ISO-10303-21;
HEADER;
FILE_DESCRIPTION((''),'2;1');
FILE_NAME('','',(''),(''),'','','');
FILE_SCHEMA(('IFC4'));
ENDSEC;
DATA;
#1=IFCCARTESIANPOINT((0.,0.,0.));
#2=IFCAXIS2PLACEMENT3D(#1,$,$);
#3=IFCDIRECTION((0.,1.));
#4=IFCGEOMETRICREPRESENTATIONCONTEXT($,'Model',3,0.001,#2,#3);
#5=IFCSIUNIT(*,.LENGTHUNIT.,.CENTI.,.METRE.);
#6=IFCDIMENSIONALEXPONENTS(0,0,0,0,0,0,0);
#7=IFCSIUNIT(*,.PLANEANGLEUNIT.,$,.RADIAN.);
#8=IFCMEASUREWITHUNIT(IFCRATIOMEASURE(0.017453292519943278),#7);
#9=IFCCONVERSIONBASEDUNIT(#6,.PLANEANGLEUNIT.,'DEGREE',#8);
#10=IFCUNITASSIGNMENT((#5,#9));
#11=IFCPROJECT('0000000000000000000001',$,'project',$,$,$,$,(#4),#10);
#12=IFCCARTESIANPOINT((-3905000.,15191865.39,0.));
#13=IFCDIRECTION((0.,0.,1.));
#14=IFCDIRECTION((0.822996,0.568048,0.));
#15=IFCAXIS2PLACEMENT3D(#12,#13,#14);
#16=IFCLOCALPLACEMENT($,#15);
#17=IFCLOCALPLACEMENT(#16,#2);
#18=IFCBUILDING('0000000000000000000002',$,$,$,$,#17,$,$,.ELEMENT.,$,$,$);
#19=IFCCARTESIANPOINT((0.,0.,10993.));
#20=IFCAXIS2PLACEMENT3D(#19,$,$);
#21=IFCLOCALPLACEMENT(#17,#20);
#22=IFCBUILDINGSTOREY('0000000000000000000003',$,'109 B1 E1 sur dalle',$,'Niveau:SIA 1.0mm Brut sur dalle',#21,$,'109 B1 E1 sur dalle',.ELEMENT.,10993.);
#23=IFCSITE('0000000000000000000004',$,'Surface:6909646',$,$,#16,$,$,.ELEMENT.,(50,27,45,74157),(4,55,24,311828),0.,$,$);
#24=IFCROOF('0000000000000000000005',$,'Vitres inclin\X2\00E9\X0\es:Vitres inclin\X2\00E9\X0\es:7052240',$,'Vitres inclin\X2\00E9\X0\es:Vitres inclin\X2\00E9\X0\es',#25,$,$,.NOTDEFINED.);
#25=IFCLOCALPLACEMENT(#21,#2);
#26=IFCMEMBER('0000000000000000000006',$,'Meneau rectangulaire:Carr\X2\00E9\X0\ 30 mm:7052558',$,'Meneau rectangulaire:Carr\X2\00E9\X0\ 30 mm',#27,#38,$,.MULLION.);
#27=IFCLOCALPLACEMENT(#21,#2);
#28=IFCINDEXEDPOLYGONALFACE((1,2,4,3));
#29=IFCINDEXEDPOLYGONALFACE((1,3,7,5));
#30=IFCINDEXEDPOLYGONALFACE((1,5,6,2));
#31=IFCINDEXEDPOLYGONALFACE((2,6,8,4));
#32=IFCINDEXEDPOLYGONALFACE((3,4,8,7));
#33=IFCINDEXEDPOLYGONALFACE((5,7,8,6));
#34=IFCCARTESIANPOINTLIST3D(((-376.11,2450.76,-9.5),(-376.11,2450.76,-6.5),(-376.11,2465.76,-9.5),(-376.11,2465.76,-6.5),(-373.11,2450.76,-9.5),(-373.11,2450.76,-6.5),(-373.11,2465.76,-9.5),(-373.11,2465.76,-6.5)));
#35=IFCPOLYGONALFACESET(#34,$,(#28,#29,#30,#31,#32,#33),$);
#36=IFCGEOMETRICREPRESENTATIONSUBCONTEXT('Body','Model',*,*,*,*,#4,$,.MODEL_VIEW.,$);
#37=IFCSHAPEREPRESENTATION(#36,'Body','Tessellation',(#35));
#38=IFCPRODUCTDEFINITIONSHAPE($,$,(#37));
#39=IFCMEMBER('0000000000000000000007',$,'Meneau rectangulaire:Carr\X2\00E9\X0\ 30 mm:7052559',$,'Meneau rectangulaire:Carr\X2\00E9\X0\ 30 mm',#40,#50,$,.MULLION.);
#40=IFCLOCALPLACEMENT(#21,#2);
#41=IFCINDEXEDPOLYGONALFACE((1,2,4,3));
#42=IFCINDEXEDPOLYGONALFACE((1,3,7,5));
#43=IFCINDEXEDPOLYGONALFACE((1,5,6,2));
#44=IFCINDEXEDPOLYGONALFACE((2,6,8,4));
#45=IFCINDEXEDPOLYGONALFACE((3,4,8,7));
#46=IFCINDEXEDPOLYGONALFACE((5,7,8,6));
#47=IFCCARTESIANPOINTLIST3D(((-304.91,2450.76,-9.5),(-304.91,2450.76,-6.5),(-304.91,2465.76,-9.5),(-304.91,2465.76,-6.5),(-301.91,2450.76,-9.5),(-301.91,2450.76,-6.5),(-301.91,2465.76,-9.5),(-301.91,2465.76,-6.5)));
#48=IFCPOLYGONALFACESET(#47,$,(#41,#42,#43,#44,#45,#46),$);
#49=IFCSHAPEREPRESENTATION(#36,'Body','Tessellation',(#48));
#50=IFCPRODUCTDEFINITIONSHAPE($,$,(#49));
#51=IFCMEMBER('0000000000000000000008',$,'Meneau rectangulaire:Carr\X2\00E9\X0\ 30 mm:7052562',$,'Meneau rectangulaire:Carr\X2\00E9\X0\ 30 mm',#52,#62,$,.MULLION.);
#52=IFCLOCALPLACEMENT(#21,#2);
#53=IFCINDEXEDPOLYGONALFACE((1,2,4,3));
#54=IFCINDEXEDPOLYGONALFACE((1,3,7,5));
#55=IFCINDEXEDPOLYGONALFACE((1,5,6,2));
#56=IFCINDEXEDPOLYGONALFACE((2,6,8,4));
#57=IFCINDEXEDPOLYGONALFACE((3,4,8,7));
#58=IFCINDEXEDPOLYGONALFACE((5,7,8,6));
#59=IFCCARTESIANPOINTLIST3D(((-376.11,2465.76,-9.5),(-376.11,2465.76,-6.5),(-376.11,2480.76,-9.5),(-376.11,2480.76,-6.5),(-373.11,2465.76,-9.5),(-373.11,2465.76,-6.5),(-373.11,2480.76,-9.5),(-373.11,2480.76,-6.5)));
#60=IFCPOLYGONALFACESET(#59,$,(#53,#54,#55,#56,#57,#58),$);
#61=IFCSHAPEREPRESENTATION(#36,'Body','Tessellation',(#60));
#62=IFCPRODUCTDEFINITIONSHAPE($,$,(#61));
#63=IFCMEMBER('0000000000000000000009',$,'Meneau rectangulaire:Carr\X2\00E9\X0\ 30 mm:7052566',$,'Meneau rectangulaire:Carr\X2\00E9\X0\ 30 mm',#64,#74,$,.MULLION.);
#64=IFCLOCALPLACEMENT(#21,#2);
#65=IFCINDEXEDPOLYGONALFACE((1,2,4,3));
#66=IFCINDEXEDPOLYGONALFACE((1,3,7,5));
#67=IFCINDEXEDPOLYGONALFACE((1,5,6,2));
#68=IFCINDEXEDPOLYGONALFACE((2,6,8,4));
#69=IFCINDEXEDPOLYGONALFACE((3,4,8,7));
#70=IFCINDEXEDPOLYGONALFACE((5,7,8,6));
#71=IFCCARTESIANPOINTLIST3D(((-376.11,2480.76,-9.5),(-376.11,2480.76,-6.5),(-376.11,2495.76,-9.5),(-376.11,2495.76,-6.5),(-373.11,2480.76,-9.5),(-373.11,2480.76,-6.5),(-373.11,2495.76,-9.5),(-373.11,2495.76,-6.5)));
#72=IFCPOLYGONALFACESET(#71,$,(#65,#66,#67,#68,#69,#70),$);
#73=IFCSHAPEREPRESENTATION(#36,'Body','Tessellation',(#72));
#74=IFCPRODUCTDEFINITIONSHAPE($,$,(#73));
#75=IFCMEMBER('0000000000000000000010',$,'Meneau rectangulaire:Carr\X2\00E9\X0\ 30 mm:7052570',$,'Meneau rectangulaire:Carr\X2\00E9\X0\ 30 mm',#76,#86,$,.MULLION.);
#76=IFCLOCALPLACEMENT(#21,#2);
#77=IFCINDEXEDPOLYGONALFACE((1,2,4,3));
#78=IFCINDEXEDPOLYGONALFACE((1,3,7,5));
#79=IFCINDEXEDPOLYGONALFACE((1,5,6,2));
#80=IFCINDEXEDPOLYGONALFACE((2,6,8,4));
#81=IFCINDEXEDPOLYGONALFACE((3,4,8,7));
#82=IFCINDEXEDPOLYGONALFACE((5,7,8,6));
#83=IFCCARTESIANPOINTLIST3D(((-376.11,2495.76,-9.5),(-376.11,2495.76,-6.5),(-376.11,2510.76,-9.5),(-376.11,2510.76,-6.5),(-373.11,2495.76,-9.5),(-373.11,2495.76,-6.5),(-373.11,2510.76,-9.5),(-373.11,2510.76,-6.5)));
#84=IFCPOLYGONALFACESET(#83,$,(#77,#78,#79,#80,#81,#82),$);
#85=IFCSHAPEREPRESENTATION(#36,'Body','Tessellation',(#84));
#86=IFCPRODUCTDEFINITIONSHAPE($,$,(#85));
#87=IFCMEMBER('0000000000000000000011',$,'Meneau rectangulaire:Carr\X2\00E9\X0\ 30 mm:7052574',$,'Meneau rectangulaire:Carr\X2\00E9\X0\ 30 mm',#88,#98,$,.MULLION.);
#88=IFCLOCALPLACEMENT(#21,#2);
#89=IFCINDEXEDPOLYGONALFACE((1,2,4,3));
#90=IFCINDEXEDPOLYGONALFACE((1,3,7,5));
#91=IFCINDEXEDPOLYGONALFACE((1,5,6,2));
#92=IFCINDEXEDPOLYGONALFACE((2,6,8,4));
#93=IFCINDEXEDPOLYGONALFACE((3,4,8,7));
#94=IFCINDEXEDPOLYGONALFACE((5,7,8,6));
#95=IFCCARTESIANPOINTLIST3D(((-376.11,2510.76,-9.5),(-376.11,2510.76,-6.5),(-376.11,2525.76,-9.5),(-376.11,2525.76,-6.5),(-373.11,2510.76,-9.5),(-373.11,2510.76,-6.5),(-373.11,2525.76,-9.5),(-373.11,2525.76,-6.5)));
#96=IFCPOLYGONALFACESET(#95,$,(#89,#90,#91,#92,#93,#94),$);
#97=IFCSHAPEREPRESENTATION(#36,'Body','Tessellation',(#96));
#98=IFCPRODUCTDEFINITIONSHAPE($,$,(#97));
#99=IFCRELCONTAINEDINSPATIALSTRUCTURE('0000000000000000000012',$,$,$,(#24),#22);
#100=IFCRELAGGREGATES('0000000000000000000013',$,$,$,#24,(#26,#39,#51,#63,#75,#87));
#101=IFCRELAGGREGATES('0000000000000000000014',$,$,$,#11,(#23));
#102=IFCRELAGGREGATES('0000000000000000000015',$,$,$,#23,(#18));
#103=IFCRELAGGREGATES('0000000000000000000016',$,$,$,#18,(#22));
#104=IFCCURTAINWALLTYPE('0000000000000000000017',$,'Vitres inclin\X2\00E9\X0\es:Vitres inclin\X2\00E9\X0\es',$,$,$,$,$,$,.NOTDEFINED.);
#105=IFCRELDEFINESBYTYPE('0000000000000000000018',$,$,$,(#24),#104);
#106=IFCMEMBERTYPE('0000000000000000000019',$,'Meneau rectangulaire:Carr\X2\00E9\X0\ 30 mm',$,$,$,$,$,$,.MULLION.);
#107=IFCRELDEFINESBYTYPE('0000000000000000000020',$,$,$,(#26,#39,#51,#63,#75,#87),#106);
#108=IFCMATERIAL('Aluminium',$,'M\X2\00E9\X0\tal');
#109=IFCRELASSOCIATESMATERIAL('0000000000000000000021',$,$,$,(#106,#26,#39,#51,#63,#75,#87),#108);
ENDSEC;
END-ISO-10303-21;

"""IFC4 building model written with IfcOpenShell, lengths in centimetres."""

from ifc_helpers import new_model, entity, si_unit, converted_unit, direction, frame, origin, place, context, subcontext, project, spatial, indexed_curve, outline, extrude, source, transform, mapped, material, type_object, type_shapes, element, aggregate, save


model = new_model("IFC4")

# Units and contexts
model_context = context("Model", 3, precision=0.001, world=origin(), true_north=direction((0.0, 1.0)))
body_context = subcontext(model_context, "Body", "Model", "MODEL_VIEW")
ifc_project = project(units=[si_unit("LENGTHUNIT", "METRE", prefix="CENTI"), converted_unit("PLANEANGLEUNIT", "DEGREE", entity("IfcRatioMeasure", 0.017453292519943278), si_unit("PLANEANGLEUNIT", "RADIAN"), dimensions=[0, 0, 0, 0, 0, 0, 0])], contexts=[model_context])

# Site, building, storey
site_placement = place(None, frame((-3905000.0, 15191865.39, 0.0), z_axis=(0.0, 0.0, 1.0), x_axis=(0.822996, 0.568048, 0.0)))
site = spatial("IfcSite", under=ifc_project, at=site_placement, Name="Surface:6909646", CompositionType="ELEMENT", RefLatitude=(50, 27, 45, 74157), RefLongitude=(4, 55, 24, 311828), RefElevation=0.0)
building_placement = place(site_placement, origin())
building = spatial("IfcBuilding", under=site, at=building_placement, CompositionType="ELEMENT")
storey_placement = place(building_placement, frame((0.0, 0.0, 10993.0)))
storey = spatial("IfcBuildingStorey", under=building, at=storey_placement, Name="109 B1 E1 sur dalle", ObjectType="Niveau:SIA 1.0mm Brut sur dalle", LongName="109 B1 E1 sur dalle", CompositionType="ELEMENT", Elevation=10993.0)

# Roof, members
curtain_wall_type = type_object("IfcCurtainWallType", Name="Vitres inclinées:Vitres inclinées", PredefinedType="NOTDEFINED")
roof_placement = place(storey_placement, frame((0.0, 0.0, -10993.0)))
roof = element("IfcRoof", 1, at=roof_placement, inside=storey, type_object=curtain_wall_type, Name="Vitres inclinées:Vitres inclinées:7052240", ObjectType="Vitres inclinées:Vitres inclinées", PredefinedType="NOTDEFINED")
ifc_material = material(Name="Aluminium", Category="Métal")
member_type_1 = type_object("IfcMemberType", Name="Meneau rectangulaire:Carré 30 mm", PredefinedType="MULLION", material=ifc_material)
shared_shape_1 = source(origin(), body_context, "Body", "SweptSolid", [
    extrude(outline(indexed_curve([(-1.5, -1.5), (1.5, -1.5), (1.5, 1.5), (-1.5, 1.5), (-1.5, -1.5)], self_intersect=False)), frame((0.0, 0.0, -15.0), z_axis=(0.0, 0.0, 1.0), x_axis=(0.0, -1.0, 0.0)), (0.0, 0.0, 1.0), 15.0),
])
type_shapes(member_type_1, [shared_shape_1])
member_1_placement = place(roof_placement, frame((-374.61, 2465.76, 10985.0), z_axis=(0.0, 1.0, 0.0), x_axis=(1.0, 0.0, 0.0)))
member_1 = element("IfcMember", 2, at=member_1_placement, type_object=member_type_1, material=ifc_material, Name="Meneau rectangulaire:Carré 30 mm:7052558", ObjectType="Meneau rectangulaire:Carré 30 mm", PredefinedType="MULLION", context=body_context, shape_type="MappedRepresentation", body=[
    mapped(shared_shape_1, transform((0.0, 0.0, 0.0), scale=1.0)),
])
member_2_placement = place(roof_placement, frame((-303.41, 2465.76, 10985.0), z_axis=(0.0, 1.0, 0.0), x_axis=(1.0, 0.0, 0.0)))
member_2 = element("IfcMember", 3, at=member_2_placement, type_object=member_type_1, material=ifc_material, Name="Meneau rectangulaire:Carré 30 mm:7052559", ObjectType="Meneau rectangulaire:Carré 30 mm", PredefinedType="MULLION", context=body_context, shape_type="MappedRepresentation", body=[
    mapped(shared_shape_1, transform((0.0, 0.0, 0.0), scale=1.0)),
])
member_3_placement = place(roof_placement, frame((-374.61, 2480.76, 10985.0), z_axis=(0.0, 1.0, 0.0), x_axis=(1.0, 0.0, 0.0)))
member_3 = element("IfcMember", 4, at=member_3_placement, type_object=member_type_1, material=ifc_material, Name="Meneau rectangulaire:Carré 30 mm:7052562", ObjectType="Meneau rectangulaire:Carré 30 mm", PredefinedType="MULLION", context=body_context, shape_type="MappedRepresentation", body=[
    mapped(shared_shape_1, transform((0.0, 0.0, 0.0), scale=1.0)),
])
member_4_placement = place(roof_placement, frame((-374.61, 2495.76, 10985.0), z_axis=(0.0, 1.0, 0.0), x_axis=(1.0, 0.0, 0.0)))
member_4 = element("IfcMember", 5, at=member_4_placement, type_object=member_type_1, material=ifc_material, Name="Meneau rectangulaire:Carré 30 mm:7052566", ObjectType="Meneau rectangulaire:Carré 30 mm", PredefinedType="MULLION", context=body_context, shape_type="MappedRepresentation", body=[
    mapped(shared_shape_1, transform((0.0, 0.0, 0.0), scale=1.0)),
])
member_5_placement = place(roof_placement, frame((-374.61, 2510.76, 10985.0), z_axis=(0.0, 1.0, 0.0), x_axis=(1.0, 0.0, 0.0)))
member_5 = element("IfcMember", 6, at=member_5_placement, type_object=member_type_1, material=ifc_material, Name="Meneau rectangulaire:Carré 30 mm:7052570", ObjectType="Meneau rectangulaire:Carré 30 mm", PredefinedType="MULLION", context=body_context, shape_type="MappedRepresentation", body=[
    mapped(shared_shape_1, transform((0.0, 0.0, 0.0), scale=1.0)),
])
member_6_placement = place(roof_placement, frame((-374.61, 2525.76, 10985.0), z_axis=(0.0, 1.0, 0.0), x_axis=(1.0, 0.0, 0.0)))
member_6 = element("IfcMember", 7, at=member_6_placement, type_object=member_type_1, material=ifc_material, Name="Meneau rectangulaire:Carré 30 mm:7052574", ObjectType="Meneau rectangulaire:Carré 30 mm", PredefinedType="MULLION", context=body_context, shape_type="MappedRepresentation", body=[
    mapped(shared_shape_1, transform((0.0, 0.0, 0.0), scale=1.0)),
])
aggregate(roof, [member_1, member_2, member_3, member_4, member_5, member_6])

save(model, "model.ifc")
